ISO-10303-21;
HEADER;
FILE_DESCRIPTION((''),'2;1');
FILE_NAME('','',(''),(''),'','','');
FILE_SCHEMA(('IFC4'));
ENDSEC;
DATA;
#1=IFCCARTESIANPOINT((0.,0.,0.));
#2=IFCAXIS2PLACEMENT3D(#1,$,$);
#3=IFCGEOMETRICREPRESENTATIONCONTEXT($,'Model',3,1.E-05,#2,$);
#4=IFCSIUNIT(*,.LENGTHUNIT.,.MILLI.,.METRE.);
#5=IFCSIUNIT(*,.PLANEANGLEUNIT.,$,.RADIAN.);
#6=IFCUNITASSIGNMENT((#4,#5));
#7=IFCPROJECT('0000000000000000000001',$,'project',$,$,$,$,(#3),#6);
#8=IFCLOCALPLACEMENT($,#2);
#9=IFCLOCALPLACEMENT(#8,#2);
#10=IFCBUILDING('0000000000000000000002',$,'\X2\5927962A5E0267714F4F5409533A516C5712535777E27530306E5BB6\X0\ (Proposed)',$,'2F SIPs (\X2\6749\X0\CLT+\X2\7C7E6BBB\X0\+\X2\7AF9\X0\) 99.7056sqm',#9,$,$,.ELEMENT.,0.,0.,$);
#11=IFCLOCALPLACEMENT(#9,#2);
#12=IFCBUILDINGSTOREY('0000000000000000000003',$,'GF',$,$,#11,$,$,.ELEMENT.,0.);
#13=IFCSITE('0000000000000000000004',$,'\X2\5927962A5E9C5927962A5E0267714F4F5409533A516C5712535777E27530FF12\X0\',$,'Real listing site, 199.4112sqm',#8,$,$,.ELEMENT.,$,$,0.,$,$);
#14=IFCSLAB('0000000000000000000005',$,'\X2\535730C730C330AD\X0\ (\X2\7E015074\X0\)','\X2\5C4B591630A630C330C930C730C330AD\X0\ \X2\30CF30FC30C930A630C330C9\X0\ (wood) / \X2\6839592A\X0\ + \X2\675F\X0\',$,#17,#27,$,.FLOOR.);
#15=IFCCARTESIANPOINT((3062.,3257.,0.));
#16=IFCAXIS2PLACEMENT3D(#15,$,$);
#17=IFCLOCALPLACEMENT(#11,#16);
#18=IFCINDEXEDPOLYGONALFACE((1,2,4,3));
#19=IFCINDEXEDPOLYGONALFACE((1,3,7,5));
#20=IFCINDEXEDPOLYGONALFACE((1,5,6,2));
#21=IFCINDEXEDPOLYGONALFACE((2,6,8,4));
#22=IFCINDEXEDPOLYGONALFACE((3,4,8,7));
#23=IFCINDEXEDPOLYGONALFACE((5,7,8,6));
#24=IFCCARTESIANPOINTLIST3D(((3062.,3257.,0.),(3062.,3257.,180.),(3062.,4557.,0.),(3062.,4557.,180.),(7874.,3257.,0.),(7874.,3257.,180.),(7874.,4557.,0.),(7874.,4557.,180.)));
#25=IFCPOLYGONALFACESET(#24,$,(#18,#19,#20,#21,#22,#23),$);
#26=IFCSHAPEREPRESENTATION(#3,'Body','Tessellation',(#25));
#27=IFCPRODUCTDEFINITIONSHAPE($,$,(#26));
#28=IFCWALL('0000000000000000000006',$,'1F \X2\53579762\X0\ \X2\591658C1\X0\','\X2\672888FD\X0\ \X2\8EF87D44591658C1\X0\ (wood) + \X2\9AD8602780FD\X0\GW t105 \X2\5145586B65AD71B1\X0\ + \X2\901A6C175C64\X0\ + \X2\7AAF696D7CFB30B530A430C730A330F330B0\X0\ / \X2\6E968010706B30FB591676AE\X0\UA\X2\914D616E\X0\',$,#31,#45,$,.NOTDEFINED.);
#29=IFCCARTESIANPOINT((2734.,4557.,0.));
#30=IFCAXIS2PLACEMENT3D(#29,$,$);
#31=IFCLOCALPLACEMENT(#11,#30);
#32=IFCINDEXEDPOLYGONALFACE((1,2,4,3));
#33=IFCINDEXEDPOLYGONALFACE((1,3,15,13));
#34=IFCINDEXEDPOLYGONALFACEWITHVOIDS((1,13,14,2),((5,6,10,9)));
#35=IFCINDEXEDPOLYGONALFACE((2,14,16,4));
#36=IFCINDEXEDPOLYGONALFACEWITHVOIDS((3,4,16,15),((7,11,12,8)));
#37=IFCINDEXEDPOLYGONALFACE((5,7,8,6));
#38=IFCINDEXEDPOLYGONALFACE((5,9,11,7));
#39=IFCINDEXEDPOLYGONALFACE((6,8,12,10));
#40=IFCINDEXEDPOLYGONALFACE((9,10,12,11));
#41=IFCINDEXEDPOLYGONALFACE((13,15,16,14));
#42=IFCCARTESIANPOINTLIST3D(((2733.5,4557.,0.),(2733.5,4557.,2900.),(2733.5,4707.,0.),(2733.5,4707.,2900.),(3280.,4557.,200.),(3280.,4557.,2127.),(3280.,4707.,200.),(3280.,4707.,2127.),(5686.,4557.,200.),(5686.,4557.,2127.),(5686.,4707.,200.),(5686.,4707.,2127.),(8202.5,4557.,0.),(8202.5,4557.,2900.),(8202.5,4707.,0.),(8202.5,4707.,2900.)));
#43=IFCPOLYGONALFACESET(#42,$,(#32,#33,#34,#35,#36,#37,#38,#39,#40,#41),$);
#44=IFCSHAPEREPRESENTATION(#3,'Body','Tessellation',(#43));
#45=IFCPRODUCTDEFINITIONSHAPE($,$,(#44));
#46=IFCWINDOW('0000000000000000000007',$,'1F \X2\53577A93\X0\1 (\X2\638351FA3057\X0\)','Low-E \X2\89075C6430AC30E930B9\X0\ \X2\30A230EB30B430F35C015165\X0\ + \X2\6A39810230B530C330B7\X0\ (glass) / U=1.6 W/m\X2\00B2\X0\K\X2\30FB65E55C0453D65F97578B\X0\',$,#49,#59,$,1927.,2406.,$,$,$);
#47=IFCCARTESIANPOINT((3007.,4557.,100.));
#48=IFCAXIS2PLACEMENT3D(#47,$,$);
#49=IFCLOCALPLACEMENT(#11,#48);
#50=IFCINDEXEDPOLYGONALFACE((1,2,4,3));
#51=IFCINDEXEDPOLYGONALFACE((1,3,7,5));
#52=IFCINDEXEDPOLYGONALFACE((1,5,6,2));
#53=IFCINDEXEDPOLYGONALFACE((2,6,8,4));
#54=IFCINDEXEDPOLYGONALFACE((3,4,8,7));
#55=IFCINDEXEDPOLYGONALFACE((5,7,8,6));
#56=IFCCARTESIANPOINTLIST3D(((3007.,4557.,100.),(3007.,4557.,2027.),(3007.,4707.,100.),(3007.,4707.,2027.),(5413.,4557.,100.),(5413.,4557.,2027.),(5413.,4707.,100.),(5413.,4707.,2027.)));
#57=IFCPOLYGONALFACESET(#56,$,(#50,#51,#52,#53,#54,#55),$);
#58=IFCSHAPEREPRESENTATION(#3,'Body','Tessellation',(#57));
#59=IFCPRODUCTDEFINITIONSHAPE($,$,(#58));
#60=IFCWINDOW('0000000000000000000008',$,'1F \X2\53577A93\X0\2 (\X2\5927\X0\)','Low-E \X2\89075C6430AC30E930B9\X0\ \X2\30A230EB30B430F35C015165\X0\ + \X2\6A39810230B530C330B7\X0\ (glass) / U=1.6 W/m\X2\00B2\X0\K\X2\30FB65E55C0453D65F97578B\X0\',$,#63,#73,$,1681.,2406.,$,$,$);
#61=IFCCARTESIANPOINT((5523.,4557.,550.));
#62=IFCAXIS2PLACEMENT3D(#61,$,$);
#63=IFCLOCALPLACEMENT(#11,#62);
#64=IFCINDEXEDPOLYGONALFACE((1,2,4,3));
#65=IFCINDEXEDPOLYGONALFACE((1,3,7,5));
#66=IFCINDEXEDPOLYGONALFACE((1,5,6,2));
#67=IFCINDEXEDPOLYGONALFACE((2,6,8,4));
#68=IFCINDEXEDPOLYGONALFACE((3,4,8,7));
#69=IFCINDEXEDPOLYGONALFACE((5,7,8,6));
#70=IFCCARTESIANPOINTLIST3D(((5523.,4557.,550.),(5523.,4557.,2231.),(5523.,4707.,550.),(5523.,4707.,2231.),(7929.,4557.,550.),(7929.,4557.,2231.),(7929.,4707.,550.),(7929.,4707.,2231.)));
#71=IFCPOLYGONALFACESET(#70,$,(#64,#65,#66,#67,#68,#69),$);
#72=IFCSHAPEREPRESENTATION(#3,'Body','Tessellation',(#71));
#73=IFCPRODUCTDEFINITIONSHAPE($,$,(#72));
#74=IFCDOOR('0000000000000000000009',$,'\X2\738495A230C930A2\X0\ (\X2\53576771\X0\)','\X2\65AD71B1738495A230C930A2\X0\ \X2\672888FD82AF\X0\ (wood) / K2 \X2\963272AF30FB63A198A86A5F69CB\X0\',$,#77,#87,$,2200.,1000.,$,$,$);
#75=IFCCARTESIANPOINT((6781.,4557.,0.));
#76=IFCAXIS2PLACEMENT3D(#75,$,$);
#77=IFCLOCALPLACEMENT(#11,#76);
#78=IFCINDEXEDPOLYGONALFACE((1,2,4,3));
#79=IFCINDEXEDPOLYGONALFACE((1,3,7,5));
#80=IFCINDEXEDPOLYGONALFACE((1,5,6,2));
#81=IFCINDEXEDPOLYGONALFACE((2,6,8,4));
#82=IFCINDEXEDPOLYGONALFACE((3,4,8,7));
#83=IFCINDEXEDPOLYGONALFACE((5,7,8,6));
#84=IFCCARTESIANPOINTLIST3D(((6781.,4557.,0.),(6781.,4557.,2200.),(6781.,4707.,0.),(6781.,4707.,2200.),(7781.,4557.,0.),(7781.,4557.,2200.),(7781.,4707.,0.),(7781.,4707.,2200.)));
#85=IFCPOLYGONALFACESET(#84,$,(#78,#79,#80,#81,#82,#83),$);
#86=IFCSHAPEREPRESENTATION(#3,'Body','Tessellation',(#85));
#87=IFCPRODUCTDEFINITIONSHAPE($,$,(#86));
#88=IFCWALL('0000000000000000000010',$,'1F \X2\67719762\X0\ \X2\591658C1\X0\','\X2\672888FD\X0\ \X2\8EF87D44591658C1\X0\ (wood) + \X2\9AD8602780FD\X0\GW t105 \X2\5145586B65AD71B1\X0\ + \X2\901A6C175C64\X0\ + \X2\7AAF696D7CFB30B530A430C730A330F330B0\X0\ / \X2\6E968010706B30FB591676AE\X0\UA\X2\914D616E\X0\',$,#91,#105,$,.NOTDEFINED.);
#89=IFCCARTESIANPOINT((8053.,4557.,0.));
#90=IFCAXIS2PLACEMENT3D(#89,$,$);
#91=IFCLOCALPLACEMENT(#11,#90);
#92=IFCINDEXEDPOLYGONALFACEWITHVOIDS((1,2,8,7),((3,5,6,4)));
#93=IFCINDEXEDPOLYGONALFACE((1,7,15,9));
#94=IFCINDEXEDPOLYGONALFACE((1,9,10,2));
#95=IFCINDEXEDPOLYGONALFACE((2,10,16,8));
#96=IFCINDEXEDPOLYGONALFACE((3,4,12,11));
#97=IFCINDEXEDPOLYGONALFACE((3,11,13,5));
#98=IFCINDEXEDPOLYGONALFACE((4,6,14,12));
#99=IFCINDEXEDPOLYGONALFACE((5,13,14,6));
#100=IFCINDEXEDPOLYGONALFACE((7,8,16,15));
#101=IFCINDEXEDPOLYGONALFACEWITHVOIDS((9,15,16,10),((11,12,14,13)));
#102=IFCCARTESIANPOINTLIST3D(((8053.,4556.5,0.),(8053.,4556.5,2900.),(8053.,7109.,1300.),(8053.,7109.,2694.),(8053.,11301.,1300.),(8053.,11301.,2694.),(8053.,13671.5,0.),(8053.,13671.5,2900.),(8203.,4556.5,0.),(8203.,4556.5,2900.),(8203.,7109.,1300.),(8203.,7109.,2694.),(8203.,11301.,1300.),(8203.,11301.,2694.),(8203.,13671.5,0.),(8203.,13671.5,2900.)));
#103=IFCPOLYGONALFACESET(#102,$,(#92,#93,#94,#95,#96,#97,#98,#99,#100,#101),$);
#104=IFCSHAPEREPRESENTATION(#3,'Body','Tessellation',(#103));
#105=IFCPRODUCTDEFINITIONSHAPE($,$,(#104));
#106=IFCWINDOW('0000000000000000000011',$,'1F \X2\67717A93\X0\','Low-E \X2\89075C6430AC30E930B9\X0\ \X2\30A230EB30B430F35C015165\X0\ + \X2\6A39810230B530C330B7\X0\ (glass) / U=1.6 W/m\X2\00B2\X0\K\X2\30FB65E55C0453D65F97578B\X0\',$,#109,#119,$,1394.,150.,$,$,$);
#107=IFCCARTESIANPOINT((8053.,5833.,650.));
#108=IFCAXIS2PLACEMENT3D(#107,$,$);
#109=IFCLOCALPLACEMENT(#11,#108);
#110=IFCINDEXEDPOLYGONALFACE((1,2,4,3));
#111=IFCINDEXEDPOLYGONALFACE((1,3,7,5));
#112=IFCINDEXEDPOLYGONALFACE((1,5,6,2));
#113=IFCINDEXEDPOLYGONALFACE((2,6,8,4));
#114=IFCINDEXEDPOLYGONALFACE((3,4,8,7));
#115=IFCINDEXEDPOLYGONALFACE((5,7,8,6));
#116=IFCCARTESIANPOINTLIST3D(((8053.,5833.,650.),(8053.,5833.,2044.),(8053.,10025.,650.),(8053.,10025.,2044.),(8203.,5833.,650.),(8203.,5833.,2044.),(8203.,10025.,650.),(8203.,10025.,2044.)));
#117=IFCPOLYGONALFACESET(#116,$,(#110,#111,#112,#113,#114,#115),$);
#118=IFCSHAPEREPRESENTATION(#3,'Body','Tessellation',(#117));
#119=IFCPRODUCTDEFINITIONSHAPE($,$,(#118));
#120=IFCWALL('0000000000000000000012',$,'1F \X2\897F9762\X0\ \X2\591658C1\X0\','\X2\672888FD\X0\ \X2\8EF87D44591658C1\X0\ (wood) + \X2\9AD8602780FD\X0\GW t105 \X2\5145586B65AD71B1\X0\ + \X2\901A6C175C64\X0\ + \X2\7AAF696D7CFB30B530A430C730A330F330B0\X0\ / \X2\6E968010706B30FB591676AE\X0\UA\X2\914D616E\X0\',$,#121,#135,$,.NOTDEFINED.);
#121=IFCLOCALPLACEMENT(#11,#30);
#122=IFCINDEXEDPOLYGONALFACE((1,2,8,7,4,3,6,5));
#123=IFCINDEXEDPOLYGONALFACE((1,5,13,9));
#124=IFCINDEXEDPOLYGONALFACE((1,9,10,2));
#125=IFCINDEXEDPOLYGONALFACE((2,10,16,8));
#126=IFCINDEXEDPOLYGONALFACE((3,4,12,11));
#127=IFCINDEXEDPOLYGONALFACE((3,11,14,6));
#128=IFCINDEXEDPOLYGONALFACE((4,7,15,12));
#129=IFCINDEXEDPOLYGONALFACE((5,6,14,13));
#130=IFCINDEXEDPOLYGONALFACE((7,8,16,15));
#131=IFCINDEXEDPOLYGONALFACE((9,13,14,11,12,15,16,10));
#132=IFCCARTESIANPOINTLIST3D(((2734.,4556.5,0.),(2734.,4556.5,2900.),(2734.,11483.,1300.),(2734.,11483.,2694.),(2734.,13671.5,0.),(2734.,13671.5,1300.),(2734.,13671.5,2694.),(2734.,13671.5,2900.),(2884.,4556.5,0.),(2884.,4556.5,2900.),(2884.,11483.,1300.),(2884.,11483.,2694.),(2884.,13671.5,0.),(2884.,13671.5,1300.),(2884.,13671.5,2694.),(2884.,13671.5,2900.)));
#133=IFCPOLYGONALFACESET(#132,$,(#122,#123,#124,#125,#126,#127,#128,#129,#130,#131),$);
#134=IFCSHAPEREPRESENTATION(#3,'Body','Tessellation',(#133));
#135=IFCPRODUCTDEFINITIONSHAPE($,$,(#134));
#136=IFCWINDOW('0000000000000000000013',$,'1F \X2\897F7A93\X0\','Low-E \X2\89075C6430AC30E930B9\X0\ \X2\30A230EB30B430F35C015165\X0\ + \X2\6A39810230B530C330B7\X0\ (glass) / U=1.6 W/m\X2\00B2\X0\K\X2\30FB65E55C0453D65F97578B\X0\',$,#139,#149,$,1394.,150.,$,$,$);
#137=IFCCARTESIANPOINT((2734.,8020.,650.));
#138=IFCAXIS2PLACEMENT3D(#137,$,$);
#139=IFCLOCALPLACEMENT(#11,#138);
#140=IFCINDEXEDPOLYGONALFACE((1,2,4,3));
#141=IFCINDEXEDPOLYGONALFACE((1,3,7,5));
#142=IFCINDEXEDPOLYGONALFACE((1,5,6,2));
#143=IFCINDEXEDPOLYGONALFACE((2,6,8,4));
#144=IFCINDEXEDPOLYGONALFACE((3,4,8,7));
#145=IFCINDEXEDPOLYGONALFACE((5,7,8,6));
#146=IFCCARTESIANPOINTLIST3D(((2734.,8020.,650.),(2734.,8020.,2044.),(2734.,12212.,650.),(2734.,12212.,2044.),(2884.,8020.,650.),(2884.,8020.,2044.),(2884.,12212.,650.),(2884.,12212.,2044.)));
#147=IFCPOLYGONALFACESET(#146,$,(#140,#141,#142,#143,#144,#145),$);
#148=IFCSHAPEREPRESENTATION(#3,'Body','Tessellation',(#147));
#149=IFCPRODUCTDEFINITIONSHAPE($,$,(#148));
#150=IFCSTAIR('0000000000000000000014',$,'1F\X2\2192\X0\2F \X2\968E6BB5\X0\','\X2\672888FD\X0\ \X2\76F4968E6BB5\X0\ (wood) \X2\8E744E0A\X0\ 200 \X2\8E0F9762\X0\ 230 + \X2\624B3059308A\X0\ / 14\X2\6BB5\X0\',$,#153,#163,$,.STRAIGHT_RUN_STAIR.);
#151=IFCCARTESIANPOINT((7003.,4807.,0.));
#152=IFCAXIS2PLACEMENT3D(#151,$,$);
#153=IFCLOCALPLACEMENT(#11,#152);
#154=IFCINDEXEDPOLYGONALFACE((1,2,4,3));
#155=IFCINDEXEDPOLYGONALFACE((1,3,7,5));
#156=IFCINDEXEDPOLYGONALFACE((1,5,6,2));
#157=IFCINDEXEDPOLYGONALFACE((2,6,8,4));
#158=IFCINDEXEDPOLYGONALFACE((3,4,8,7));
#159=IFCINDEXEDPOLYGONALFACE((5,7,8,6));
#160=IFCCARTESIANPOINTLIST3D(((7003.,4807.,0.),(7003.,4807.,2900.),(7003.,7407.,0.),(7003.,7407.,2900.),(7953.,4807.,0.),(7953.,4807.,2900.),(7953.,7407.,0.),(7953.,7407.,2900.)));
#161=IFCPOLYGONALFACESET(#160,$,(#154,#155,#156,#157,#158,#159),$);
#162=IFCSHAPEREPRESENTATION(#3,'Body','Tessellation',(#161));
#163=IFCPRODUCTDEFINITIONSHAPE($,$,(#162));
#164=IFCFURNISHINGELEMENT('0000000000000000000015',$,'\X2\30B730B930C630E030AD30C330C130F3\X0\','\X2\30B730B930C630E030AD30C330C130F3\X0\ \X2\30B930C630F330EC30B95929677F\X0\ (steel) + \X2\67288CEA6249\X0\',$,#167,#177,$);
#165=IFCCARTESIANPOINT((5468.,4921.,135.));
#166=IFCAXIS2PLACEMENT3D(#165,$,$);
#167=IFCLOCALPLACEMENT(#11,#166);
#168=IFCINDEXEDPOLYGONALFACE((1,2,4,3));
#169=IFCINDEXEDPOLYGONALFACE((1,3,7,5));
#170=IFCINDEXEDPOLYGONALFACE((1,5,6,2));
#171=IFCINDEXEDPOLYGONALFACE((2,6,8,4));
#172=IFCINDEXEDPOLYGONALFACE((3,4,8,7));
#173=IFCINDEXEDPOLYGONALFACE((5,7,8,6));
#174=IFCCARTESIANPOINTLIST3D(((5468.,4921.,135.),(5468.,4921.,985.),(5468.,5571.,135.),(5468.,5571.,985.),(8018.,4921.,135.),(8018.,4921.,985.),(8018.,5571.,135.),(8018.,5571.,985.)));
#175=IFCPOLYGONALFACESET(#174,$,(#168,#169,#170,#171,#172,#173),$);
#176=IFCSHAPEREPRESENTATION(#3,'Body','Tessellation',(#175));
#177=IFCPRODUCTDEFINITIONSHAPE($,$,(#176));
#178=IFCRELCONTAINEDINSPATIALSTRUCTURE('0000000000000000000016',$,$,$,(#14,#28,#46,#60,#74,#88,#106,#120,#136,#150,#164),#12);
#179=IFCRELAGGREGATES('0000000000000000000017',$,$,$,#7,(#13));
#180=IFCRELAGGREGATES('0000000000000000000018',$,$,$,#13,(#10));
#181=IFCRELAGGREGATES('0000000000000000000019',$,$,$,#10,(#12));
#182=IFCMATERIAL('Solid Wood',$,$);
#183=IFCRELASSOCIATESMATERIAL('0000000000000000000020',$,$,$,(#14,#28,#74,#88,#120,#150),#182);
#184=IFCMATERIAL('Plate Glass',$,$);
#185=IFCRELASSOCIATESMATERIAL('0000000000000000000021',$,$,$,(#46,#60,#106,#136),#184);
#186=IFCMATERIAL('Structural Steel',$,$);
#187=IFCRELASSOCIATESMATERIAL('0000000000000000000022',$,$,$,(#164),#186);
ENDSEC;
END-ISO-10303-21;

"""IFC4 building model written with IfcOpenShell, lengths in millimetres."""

from ifc_helpers import new_model, si_unit, frame, frame_2d, origin, place, context, project, spatial, rectangle, extrude, material, element, fill, save


model = new_model("IFC4")

# Units and contexts
model_context = context("Model", 3, precision=1e-05, world=origin())
ifc_project = project(units=[si_unit("LENGTHUNIT", "METRE", prefix="MILLI"), si_unit("PLANEANGLEUNIT", "RADIAN")], contexts=[model_context])

# Site, building, storey
site_placement = place(None, origin())
site = spatial("IfcSite", under=ifc_project, at=site_placement, Name="大阪府大阪市東住吉区公園南矢田２", ObjectType="Real listing site, 199.4112sqm", CompositionType="ELEMENT", RefElevation=0.0)
building_placement = place(site_placement, origin())
building = spatial("IfcBuilding", under=site, at=building_placement, Name="大阪市東住吉区公園南矢田の家 (Proposed)", ObjectType="2F SIPs (杉CLT+籾殻+竹) 99.7056sqm", CompositionType="ELEMENT", ElevationOfRefHeight=0.0, ElevationOfTerrain=0.0)
storey_placement = place(building_placement, origin())
storey = spatial("IfcBuildingStorey", under=building, at=storey_placement, Name="GF", CompositionType="ELEMENT", Elevation=0.0)

# Slab
ifc_material_1 = material(Name="Solid Wood")
slab_1_placement = place(storey_placement, frame((3062.0, 3257.0, 0.0)))
element("IfcSlab", 1, at=slab_1_placement, inside=storey, material=ifc_material_1, Name="南デッキ (縁側)", Description="屋外ウッドデッキ ハードウッド (wood) / 根太 + 束", PredefinedType="FLOOR", context=model_context, shape_type="SweptSolid", body=[
    extrude(rectangle(XDim=4812.0, YDim=1300.0, at=frame_2d((2406.0, 650.0))), frame((3062.0, 3257.0, 0.0)), (0.0, 0.0, 1.0), 180.0),
])

# Wall, openings, windows, door
wall_1_placement = place(storey_placement, frame((2734.0, 4557.0, 0.0)))
wall_1 = element("IfcWall", 2, at=wall_1_placement, inside=storey, material=ifc_material_1, Name="1F 南面 外壁", Description="木製 軸組外壁 (wood) + 高性能GW t105 充填断熱 + 通気層 + 窯業系サイディング / 準耐火・外皮UA配慮", PredefinedType="NOTDEFINED", context=model_context, shape_type="SweptSolid", body=[
    extrude(rectangle(XDim=5469.0, YDim=150.0, at=frame_2d((2734.0, 75.0))), frame((2734.0, 4557.0, 0.0)), (0.0, 0.0, 1.0), 2900.0),
])
opening_1_placement = place(storey_placement, frame((3007.0, 4557.0, 100.0)))
opening_1 = element("IfcOpeningElement", 3, at=opening_1_placement, cuts=wall_1, PredefinedType="NOTDEFINED", context=model_context, shape_type="SweptSolid", body=[
    extrude(rectangle(XDim=2406.0, YDim=150.0, at=frame_2d((1203.0, 75.0))), frame((3007.0, 4557.0, 100.0)), (0.0, 0.0, 1.0), 1927.0),
])
opening_2_placement = place(storey_placement, frame((5523.0, 4557.0, 550.0)))
opening_2 = element("IfcOpeningElement", 4, at=opening_2_placement, cuts=wall_1, PredefinedType="NOTDEFINED", context=model_context, shape_type="SweptSolid", body=[
    extrude(rectangle(XDim=2406.0, YDim=150.0, at=frame_2d((1203.0, 75.0))), frame((5523.0, 4557.0, 550.0)), (0.0, 0.0, 1.0), 1681.0),
])
opening_3_placement = place(storey_placement, frame((6781.0, 4557.0, 0.0)))
opening_3 = element("IfcOpeningElement", 5, at=opening_3_placement, cuts=wall_1, PredefinedType="NOTDEFINED", context=model_context, shape_type="SweptSolid", body=[
    extrude(rectangle(XDim=1000.0, YDim=150.0, at=frame_2d((500.0, 75.0))), frame((6781.0, 4557.0, 0.0)), (0.0, 0.0, 1.0), 2200.0),
])
ifc_material_2 = material(Name="Plate Glass")
window_1_placement = place(storey_placement, frame((3007.0, 4557.0, 100.0)))
window_1 = element("IfcWindow", 6, at=window_1_placement, inside=storey, material=ifc_material_2, Name="1F 南窓1 (掃出し)", Description="Low-E 複層ガラス アルゴン封入 + 樹脂サッシ (glass) / U=1.6 W/m²K・日射取得型", OverallHeight=1927.0, OverallWidth=2406.0, context=model_context, shape_type="SweptSolid", body=[
    extrude(rectangle(XDim=2406.0, YDim=150.0, at=frame_2d((1203.0, 75.0))), frame((3007.0, 4557.0, 100.0)), (0.0, 0.0, 1.0), 1927.0),
])
fill(opening_1, window_1)
window_2_placement = place(storey_placement, frame((5523.0, 4557.0, 550.0)))
window_2 = element("IfcWindow", 7, at=window_2_placement, inside=storey, material=ifc_material_2, Name="1F 南窓2 (大)", Description="Low-E 複層ガラス アルゴン封入 + 樹脂サッシ (glass) / U=1.6 W/m²K・日射取得型", OverallHeight=1681.0, OverallWidth=2406.0, context=model_context, shape_type="SweptSolid", body=[
    extrude(rectangle(XDim=2406.0, YDim=150.0, at=frame_2d((1203.0, 75.0))), frame((5523.0, 4557.0, 550.0)), (0.0, 0.0, 1.0), 1681.0),
])
fill(opening_2, window_2)
door_placement = place(storey_placement, frame((6781.0, 4557.0, 0.0)))
door = element("IfcDoor", 8, at=door_placement, inside=storey, material=ifc_material_1, Name="玄関ドア (南東)", Description="断熱玄関ドア 木製芯 (wood) / K2 防犯・採風機構", OverallHeight=2200.0, OverallWidth=1000.0, context=model_context, shape_type="SweptSolid", body=[
    extrude(rectangle(XDim=1000.0, YDim=150.0, at=frame_2d((500.0, 75.0))), frame((6781.0, 4557.0, 0.0)), (0.0, 0.0, 1.0), 2200.0),
])
fill(opening_3, door)

# Walls, openings, windows
wall_2_placement = place(storey_placement, frame((8053.0, 4557.0, 0.0)))
wall_2 = element("IfcWall", 9, at=wall_2_placement, inside=storey, material=ifc_material_1, Name="1F 東面 外壁", Description="木製 軸組外壁 (wood) + 高性能GW t105 充填断熱 + 通気層 + 窯業系サイディング / 準耐火・外皮UA配慮", PredefinedType="NOTDEFINED", context=model_context, shape_type="SweptSolid", body=[
    extrude(rectangle(XDim=150.0, YDim=9115.0, at=frame_2d((75.0, 4557.0))), frame((8053.0, 4557.0, 0.0)), (0.0, 0.0, 1.0), 2900.0),
])
opening_4_placement = place(storey_placement, frame((8053.0, 5833.0, 650.0)))
opening_4 = element("IfcOpeningElement", 10, at=opening_4_placement, cuts=wall_2, PredefinedType="NOTDEFINED", context=model_context, shape_type="SweptSolid", body=[
    extrude(rectangle(XDim=150.0, YDim=4192.0, at=frame_2d((75.0, 2096.0))), frame((8053.0, 5833.0, 650.0)), (0.0, 0.0, 1.0), 1394.0),
])
window_3_placement = place(storey_placement, frame((8053.0, 5833.0, 650.0)))
window_3 = element("IfcWindow", 11, at=window_3_placement, inside=storey, material=ifc_material_2, Name="1F 東窓", Description="Low-E 複層ガラス アルゴン封入 + 樹脂サッシ (glass) / U=1.6 W/m²K・日射取得型", OverallHeight=1394.0, OverallWidth=150.0, context=model_context, shape_type="SweptSolid", body=[
    extrude(rectangle(XDim=150.0, YDim=4192.0, at=frame_2d((75.0, 2096.0))), frame((8053.0, 5833.0, 650.0)), (0.0, 0.0, 1.0), 1394.0),
])
fill(opening_4, window_3)
wall_3_placement = place(storey_placement, frame((2734.0, 4557.0, 0.0)))
wall_3 = element("IfcWall", 12, at=wall_3_placement, inside=storey, material=ifc_material_1, Name="1F 西面 外壁", Description="木製 軸組外壁 (wood) + 高性能GW t105 充填断熱 + 通気層 + 窯業系サイディング / 準耐火・外皮UA配慮", PredefinedType="NOTDEFINED", context=model_context, shape_type="SweptSolid", body=[
    extrude(rectangle(XDim=150.0, YDim=9115.0, at=frame_2d((75.0, 4557.0))), frame((2734.0, 4557.0, 0.0)), (0.0, 0.0, 1.0), 2900.0),
])
opening_5_placement = place(storey_placement, frame((2734.0, 8020.0, 650.0)))
opening_5 = element("IfcOpeningElement", 13, at=opening_5_placement, cuts=wall_3, PredefinedType="NOTDEFINED", context=model_context, shape_type="SweptSolid", body=[
    extrude(rectangle(XDim=150.0, YDim=4192.0, at=frame_2d((75.0, 2096.0))), frame((2734.0, 8020.0, 650.0)), (0.0, 0.0, 1.0), 1394.0),
])
window_4_placement = place(storey_placement, frame((2734.0, 8020.0, 650.0)))
window_4 = element("IfcWindow", 14, at=window_4_placement, inside=storey, material=ifc_material_2, Name="1F 西窓", Description="Low-E 複層ガラス アルゴン封入 + 樹脂サッシ (glass) / U=1.6 W/m²K・日射取得型", OverallHeight=1394.0, OverallWidth=150.0, context=model_context, shape_type="SweptSolid", body=[
    extrude(rectangle(XDim=150.0, YDim=4192.0, at=frame_2d((75.0, 2096.0))), frame((2734.0, 8020.0, 650.0)), (0.0, 0.0, 1.0), 1394.0),
])
fill(opening_5, window_4)

# Stair
stair_placement = place(storey_placement, frame((7003.0, 4807.0, 0.0)))
element("IfcStair", 15, at=stair_placement, inside=storey, material=ifc_material_1, Name="1F→2F 階段", Description="木製 直階段 (wood) 蹴上 200 踏面 230 + 手すり / 14段", PredefinedType="STRAIGHT_RUN_STAIR", context=model_context, shape_type="SweptSolid", body=[
    extrude(rectangle(XDim=950.0, YDim=2600.0, at=frame_2d((475.0, 1300.0))), frame((7003.0, 4807.0, 0.0)), (0.0, 0.0, 1.0), 2900.0),
])

# Furnishing element
ifc_material_3 = material(Name="Structural Steel")
furnishing_placement = place(storey_placement, frame((5468.0, 4921.0, 135.0)))
element("IfcFurnishingElement", 16, at=furnishing_placement, inside=storey, material=ifc_material_3, Name="システムキッチン", Description="システムキッチン ステンレス天板 (steel) + 木質扉", context=model_context, shape_type="SweptSolid", body=[
    extrude(rectangle(XDim=2550.0, YDim=650.0, at=frame_2d((1275.0, 325.0))), frame((5468.0, 4921.0, 135.0)), (0.0, 0.0, 1.0), 850.0),
])

save(model, "model.ifc")
